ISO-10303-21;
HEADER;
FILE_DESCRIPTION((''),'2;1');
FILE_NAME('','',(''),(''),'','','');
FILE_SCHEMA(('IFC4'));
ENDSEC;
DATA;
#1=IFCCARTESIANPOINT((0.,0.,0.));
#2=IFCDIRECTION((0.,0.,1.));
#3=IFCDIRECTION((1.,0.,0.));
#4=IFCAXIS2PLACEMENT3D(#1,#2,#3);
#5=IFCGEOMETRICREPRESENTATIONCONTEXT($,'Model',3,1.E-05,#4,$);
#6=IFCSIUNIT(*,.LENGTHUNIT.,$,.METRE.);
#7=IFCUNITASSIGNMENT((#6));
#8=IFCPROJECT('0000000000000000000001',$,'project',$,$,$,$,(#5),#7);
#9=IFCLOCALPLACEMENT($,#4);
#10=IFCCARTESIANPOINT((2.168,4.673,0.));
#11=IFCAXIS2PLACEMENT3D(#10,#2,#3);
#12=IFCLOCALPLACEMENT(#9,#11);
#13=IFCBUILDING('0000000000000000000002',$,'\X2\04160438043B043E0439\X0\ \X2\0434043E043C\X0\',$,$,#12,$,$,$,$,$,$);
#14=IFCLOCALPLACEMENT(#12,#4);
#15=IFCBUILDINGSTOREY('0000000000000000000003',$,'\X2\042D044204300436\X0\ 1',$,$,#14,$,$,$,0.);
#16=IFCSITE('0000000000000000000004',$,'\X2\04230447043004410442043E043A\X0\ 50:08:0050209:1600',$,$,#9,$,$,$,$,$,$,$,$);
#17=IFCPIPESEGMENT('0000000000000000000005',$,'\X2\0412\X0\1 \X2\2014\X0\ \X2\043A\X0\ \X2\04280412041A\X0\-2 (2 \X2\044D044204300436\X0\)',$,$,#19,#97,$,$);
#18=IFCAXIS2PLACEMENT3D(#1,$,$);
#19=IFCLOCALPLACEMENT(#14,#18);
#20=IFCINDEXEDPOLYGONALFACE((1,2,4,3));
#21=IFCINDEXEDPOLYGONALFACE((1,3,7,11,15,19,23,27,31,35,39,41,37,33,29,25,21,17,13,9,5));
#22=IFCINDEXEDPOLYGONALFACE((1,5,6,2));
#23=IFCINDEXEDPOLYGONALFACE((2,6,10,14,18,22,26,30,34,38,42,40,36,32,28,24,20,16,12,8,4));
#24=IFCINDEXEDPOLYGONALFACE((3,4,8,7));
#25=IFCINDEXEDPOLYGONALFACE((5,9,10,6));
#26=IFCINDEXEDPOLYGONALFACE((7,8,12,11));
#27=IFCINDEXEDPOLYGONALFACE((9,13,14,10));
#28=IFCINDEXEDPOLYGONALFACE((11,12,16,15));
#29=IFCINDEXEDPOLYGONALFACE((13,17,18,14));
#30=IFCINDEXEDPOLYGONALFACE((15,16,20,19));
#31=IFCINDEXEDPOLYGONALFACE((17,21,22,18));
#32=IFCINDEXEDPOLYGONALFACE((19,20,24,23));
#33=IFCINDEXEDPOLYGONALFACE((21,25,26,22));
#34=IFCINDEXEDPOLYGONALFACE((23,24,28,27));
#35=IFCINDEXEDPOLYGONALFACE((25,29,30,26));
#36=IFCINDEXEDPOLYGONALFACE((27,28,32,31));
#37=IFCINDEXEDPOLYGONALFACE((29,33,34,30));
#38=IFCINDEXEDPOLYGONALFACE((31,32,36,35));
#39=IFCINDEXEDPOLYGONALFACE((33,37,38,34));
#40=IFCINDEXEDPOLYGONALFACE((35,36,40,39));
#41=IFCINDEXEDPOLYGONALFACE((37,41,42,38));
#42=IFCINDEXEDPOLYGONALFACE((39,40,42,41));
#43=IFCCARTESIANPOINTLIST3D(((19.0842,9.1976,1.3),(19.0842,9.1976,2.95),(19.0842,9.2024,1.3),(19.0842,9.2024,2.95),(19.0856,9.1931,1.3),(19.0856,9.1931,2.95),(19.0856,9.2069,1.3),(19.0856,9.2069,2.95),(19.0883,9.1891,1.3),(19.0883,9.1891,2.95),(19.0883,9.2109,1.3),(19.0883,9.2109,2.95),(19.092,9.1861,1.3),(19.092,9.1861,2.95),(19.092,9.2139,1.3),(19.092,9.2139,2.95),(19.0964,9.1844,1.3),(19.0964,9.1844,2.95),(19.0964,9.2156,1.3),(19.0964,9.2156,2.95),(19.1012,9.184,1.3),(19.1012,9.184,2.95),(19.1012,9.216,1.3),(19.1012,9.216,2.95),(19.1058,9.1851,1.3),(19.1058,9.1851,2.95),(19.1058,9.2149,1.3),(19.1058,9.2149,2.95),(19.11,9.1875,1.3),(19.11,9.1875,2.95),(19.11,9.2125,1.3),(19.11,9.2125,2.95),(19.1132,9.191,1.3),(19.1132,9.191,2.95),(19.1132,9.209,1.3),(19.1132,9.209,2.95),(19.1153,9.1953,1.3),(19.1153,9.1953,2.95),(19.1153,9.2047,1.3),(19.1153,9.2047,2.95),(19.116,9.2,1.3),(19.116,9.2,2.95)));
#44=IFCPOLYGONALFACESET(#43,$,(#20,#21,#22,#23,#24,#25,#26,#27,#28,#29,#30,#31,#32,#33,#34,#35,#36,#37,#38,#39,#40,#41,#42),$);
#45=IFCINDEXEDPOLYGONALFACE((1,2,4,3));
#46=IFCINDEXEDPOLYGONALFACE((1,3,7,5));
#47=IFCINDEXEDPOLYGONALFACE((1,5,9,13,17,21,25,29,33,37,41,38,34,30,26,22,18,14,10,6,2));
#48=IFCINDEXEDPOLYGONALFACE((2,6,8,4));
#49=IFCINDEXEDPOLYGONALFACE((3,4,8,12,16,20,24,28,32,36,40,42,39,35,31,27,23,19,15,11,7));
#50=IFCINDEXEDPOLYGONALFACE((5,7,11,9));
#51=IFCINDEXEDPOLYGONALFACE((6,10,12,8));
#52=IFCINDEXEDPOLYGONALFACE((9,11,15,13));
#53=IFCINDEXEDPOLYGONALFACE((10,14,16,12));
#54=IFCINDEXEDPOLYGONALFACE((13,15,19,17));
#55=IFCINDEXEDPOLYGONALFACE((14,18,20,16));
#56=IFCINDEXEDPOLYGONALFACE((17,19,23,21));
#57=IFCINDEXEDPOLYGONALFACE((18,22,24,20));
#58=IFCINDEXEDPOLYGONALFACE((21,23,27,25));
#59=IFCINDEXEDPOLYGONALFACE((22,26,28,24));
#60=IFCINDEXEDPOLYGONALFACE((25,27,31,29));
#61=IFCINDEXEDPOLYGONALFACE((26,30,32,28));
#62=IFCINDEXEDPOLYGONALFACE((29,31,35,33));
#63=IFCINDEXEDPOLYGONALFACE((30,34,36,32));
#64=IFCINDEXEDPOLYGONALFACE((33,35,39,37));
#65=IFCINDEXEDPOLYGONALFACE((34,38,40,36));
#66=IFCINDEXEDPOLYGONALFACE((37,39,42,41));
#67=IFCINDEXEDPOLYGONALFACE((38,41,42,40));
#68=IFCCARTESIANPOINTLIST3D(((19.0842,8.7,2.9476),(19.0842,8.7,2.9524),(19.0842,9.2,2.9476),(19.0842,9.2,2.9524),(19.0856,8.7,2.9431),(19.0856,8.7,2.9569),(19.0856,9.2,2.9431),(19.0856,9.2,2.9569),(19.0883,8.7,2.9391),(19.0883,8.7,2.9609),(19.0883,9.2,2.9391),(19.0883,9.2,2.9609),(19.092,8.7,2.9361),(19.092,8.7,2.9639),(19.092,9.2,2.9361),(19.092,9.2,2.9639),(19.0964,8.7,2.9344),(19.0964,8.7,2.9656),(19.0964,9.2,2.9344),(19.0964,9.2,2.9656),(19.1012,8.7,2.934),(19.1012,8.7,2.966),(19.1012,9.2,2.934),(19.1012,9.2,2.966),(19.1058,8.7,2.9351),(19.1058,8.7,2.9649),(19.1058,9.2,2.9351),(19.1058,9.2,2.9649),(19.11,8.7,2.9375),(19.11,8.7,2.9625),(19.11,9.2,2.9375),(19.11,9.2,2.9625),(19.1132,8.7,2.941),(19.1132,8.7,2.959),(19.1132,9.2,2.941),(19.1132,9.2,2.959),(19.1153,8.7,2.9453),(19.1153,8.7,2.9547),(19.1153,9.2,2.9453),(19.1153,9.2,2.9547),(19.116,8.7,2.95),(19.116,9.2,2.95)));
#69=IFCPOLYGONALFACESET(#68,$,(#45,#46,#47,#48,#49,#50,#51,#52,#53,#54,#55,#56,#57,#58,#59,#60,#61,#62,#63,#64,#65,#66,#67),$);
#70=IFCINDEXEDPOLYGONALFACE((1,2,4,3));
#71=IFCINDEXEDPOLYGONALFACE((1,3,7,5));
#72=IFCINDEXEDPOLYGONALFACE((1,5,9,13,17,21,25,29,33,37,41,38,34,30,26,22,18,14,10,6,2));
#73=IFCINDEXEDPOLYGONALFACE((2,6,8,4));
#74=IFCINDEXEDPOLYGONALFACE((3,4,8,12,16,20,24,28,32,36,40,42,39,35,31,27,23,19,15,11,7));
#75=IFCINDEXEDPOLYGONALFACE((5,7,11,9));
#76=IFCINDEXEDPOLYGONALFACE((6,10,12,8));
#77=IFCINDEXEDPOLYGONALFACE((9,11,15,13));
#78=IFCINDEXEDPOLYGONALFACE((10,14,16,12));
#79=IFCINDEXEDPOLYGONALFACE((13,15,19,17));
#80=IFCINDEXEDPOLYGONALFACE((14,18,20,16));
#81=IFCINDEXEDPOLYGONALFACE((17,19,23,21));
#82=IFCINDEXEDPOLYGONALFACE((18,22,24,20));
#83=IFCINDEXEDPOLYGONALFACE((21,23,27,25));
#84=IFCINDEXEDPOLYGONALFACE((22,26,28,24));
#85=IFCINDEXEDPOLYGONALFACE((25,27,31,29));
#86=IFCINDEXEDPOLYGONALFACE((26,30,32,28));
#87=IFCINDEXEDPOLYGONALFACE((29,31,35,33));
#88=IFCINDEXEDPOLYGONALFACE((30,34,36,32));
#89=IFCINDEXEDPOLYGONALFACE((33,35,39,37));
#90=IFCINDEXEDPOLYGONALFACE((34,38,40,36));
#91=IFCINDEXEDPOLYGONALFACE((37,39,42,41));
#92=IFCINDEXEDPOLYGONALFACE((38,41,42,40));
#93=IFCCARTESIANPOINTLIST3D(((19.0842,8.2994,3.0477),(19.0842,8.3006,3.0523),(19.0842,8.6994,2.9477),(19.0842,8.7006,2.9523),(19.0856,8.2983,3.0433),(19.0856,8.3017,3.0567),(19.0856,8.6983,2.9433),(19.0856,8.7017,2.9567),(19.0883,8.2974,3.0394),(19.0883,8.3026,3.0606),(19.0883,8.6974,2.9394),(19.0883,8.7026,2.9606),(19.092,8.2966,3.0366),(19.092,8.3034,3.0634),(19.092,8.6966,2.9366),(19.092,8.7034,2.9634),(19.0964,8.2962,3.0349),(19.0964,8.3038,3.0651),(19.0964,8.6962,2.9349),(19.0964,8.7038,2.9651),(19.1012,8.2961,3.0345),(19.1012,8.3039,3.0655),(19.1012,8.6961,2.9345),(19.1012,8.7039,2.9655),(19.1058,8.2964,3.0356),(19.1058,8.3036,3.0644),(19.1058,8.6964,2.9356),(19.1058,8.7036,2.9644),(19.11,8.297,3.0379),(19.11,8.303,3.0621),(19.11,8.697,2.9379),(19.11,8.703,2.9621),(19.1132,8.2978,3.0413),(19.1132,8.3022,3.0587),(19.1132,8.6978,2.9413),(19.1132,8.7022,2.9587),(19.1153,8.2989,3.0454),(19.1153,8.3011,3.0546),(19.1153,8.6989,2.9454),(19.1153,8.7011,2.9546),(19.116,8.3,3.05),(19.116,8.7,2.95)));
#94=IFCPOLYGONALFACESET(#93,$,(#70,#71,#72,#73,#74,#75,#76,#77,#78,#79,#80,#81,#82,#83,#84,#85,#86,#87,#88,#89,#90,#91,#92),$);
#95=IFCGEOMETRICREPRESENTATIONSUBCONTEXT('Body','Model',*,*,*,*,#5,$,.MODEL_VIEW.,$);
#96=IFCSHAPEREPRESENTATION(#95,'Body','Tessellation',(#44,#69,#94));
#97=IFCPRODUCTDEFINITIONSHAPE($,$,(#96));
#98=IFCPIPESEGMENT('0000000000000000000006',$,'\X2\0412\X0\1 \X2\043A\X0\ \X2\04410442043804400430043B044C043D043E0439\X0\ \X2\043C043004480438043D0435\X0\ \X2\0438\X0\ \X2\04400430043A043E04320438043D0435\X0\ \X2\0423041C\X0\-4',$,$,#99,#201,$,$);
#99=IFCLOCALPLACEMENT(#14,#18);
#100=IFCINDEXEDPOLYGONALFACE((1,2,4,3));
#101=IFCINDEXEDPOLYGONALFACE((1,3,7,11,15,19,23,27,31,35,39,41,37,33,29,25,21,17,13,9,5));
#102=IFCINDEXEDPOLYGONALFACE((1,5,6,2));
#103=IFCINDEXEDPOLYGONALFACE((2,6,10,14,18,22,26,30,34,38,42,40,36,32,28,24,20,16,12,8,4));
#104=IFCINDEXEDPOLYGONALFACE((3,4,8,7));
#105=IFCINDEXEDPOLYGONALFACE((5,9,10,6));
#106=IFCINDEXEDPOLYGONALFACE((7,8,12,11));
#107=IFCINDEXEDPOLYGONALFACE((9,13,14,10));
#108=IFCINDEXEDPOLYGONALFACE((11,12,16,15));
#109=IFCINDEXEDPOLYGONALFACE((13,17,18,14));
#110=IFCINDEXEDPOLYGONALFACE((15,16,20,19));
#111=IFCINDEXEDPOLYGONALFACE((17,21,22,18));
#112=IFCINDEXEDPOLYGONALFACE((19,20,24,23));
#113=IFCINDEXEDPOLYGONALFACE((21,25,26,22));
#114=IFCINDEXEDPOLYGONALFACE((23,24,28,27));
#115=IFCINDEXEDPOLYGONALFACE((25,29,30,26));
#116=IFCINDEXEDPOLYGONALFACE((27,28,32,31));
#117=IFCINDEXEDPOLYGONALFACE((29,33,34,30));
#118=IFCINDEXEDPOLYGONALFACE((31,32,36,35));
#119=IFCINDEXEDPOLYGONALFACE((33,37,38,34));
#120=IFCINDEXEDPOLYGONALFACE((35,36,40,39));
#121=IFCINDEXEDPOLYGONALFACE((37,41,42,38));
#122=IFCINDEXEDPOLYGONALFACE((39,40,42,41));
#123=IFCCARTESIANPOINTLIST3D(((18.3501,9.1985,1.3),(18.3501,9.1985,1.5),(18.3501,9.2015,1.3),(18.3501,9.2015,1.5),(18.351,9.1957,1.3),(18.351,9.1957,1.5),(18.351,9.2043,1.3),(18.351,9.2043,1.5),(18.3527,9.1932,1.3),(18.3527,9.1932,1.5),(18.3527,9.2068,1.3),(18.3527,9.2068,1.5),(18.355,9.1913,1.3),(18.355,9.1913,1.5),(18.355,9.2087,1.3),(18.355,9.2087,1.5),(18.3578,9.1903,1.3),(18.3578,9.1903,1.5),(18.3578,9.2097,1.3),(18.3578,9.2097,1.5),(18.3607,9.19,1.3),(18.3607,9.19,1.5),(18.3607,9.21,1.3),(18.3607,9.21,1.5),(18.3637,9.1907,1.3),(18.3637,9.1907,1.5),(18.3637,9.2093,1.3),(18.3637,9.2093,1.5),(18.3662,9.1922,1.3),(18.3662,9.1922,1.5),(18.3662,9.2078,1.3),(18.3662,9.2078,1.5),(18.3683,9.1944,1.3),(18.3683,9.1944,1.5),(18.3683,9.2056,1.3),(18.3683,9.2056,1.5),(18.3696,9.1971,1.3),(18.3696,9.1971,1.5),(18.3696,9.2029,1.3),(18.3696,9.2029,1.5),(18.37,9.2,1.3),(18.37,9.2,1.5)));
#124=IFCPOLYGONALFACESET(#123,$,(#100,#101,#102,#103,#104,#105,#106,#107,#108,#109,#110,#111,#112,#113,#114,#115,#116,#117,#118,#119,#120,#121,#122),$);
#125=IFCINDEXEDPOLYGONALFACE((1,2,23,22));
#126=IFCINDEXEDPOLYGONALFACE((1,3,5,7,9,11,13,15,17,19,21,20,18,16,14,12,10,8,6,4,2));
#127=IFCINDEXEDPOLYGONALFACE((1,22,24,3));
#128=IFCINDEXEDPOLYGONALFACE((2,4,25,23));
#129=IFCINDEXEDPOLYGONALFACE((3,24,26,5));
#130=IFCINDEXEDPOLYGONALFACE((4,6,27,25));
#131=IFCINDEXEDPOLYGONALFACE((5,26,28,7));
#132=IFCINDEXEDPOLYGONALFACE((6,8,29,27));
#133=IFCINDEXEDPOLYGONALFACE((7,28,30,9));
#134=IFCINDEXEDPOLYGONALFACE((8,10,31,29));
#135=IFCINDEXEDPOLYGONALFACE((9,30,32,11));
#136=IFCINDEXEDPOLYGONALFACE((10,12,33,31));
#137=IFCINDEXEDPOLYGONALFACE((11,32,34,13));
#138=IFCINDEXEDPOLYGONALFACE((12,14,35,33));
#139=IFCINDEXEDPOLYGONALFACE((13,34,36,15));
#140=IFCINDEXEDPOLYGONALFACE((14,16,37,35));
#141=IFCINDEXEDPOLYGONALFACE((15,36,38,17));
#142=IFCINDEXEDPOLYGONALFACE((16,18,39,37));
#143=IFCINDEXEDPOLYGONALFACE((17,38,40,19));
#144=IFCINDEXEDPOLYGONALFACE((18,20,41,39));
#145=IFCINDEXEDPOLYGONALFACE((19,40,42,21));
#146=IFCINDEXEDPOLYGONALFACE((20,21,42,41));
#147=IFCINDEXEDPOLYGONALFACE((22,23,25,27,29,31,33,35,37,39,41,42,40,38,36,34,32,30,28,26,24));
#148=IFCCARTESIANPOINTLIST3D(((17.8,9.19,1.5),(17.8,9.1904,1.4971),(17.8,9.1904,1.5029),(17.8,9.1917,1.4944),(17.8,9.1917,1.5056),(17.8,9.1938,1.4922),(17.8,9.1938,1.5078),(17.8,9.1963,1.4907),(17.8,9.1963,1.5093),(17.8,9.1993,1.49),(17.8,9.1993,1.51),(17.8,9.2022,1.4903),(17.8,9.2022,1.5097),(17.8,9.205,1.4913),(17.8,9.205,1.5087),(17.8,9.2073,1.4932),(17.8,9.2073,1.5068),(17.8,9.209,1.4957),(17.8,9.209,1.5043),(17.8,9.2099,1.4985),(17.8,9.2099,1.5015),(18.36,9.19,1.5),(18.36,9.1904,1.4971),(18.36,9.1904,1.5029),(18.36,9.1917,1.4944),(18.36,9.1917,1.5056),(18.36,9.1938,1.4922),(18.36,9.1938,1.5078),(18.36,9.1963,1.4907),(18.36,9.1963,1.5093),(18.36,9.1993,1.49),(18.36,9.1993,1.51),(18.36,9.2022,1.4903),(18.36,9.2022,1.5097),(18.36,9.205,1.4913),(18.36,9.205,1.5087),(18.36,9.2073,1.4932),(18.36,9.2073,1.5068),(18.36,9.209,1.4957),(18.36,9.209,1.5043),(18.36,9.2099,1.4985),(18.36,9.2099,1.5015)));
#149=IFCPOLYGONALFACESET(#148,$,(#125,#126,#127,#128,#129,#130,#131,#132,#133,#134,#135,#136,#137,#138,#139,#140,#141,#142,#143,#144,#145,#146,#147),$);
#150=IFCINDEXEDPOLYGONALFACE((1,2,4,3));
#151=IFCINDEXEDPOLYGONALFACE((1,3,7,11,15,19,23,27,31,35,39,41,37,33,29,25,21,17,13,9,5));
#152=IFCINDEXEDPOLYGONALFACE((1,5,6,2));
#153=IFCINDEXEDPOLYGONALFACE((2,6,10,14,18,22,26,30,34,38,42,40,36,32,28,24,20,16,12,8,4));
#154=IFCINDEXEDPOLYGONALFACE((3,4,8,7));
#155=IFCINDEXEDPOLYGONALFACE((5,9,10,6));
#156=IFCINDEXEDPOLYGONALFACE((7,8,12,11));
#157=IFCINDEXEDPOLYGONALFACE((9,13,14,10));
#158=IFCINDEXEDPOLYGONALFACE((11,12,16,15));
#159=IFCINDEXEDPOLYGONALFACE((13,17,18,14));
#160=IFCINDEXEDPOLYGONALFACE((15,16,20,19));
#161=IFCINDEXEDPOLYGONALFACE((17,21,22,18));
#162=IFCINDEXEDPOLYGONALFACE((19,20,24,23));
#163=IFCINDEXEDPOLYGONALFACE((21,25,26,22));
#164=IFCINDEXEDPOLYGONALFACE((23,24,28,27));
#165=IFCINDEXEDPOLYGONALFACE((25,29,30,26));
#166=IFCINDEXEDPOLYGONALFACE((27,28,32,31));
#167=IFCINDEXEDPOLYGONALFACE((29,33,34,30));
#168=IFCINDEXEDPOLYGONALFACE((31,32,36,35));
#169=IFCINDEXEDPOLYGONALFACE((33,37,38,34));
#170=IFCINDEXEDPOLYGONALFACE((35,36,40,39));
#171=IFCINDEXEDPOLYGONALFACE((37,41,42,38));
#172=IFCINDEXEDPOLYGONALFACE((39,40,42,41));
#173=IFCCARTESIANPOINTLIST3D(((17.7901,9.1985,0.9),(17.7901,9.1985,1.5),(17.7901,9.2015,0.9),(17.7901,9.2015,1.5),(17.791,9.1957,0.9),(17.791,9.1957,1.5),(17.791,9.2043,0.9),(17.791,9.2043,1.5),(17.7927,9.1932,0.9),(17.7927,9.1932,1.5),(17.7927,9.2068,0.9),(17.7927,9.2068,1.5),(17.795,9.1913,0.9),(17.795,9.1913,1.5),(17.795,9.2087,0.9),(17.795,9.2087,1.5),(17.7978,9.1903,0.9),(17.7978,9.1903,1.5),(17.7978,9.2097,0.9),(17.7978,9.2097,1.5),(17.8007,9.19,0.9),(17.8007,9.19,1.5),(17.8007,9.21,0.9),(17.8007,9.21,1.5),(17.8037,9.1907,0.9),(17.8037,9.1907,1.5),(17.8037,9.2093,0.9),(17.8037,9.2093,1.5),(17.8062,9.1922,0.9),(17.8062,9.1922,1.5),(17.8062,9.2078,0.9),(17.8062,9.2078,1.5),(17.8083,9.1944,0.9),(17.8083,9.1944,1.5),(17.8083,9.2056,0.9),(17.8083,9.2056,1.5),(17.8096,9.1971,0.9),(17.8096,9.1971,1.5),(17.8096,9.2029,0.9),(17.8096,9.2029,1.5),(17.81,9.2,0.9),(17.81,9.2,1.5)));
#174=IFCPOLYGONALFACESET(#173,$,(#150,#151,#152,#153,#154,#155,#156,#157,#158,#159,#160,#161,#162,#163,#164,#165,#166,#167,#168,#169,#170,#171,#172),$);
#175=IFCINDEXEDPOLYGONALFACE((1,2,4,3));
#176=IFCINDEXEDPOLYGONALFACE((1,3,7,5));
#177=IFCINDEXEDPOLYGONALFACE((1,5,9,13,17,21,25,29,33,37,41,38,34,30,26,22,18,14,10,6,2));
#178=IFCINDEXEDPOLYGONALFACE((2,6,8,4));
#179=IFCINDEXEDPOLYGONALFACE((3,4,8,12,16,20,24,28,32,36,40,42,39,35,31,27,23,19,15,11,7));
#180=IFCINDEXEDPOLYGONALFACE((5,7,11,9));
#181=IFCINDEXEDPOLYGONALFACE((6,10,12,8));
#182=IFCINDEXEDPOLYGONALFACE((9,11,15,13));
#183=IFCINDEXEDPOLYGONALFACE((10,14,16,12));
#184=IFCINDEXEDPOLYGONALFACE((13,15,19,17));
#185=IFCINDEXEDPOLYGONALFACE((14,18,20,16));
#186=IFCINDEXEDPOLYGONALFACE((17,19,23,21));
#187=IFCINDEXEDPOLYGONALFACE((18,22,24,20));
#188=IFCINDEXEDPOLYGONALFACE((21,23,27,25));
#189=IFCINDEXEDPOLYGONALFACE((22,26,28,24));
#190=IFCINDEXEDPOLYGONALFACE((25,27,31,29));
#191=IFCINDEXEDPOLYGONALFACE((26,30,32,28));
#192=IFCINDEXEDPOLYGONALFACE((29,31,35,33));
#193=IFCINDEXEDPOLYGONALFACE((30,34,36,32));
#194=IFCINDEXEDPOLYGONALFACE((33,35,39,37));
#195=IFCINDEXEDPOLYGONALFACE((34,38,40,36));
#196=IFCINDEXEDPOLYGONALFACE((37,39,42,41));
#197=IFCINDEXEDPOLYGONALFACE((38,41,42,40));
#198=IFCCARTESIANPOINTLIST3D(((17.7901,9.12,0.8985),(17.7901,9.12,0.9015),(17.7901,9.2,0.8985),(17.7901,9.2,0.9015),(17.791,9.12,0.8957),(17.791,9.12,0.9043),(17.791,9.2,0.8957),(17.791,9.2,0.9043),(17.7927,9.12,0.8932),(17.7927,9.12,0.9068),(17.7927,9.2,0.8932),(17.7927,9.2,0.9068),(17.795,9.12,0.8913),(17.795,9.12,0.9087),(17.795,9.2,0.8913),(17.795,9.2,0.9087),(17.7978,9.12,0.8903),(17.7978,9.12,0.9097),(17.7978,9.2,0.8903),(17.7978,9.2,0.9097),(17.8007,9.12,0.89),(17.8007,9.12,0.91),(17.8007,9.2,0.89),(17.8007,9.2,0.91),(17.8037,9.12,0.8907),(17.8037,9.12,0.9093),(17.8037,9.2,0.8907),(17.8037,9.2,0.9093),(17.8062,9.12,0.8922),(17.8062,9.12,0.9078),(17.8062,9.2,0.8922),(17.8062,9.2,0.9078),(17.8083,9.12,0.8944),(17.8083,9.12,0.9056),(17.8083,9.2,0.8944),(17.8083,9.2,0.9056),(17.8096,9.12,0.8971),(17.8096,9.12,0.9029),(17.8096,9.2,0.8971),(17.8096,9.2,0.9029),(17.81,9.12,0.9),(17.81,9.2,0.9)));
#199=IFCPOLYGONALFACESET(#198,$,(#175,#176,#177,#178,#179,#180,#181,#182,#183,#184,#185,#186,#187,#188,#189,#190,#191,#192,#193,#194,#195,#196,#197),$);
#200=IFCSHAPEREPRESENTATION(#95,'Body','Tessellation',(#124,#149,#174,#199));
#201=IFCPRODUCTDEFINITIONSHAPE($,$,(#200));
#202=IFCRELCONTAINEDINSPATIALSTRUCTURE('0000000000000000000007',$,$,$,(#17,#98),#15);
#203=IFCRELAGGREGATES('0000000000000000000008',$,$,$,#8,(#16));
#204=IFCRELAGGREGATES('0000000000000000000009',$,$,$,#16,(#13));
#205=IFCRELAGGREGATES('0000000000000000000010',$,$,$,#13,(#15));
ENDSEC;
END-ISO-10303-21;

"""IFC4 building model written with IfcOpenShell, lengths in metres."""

from ifc_helpers import new_model, si_unit, frame, origin_with_axes, origin_2d, place, context, subcontext, project, spatial, circle, extrude, element, save


model = new_model("IFC4")

# Units and contexts
model_context = context("Model", 3, precision=1e-05, world=origin_with_axes())
body_context = subcontext(model_context, "Body", "Model", "MODEL_VIEW")
ifc_project = project(units=[si_unit("LENGTHUNIT", "METRE")], contexts=[model_context])

# Site, building, storey
site_placement = place(None, origin_with_axes())
site = spatial("IfcSite", under=ifc_project, at=site_placement, Name="Участок 50:08:0050209:1600")
building_placement = place(site_placement, frame((2.168, 4.673, 0.0), z_axis=(0.0, 0.0, 1.0), x_axis=(1.0, 0.0, 0.0)))
building = spatial("IfcBuilding", under=site, at=building_placement, Name="Жилой дом")
storey_placement = place(building_placement, origin_with_axes())
storey = spatial("IfcBuildingStorey", under=building, at=storey_placement, Name="Этаж 1", Elevation=0.0)

# Pipe segments
pipe_segment_1_placement = place(storey_placement, origin_with_axes())
element("IfcPipeSegment", 1, at=pipe_segment_1_placement, inside=storey, Name="В1 — к ШВК-2 (2 этаж)", context=body_context, shape_type="SweptSolid", body=[
    extrude(circle(Radius=0.016, at=origin_2d()), frame((19.1, 9.2, 1.3), z_axis=(0.0, 0.0, 1.0), x_axis=(1.0, 0.0, 0.0)), (0.0, 0.0, 1.0), 1.65),
    extrude(circle(Radius=0.016, at=origin_2d()), frame((19.1, 9.2, 2.95), z_axis=(0.0, -1.0, 0.0), x_axis=(1.0, 0.0, 0.0)), (0.0, 0.0, 1.0), 0.5),
    extrude(circle(Radius=0.016, at=origin_2d()), frame((19.1, 8.7, 2.95), z_axis=(0.0, -0.970143, 0.242536), x_axis=(1.0, 0.0, 0.0)), (0.0, 0.0, 1.0), 0.4123),
])
pipe_segment_2_placement = place(storey_placement, origin_with_axes())
element("IfcPipeSegment", 2, at=pipe_segment_2_placement, inside=storey, Name="В1 к стиральной машине и раковине УМ-4", context=body_context, shape_type="SweptSolid", body=[
    extrude(circle(Radius=0.01, at=origin_2d()), frame((18.36, 9.2, 1.3), z_axis=(0.0, 0.0, 1.0), x_axis=(1.0, 0.0, 0.0)), (0.0, 0.0, 1.0), 0.2),
    extrude(circle(Radius=0.01, at=origin_2d()), frame((18.36, 9.2, 1.5), z_axis=(-1.0, 0.0, 0.0), x_axis=(0.0, -1.0, 0.0)), (0.0, 0.0, 1.0), 0.56),
    extrude(circle(Radius=0.01, at=origin_2d()), frame((17.8, 9.2, 1.5), z_axis=(0.0, 0.0, -1.0), x_axis=(1.0, 0.0, 0.0)), (0.0, 0.0, 1.0), 0.6),
    extrude(circle(Radius=0.01, at=origin_2d()), frame((17.8, 9.2, 0.9), z_axis=(0.0, -1.0, 0.0), x_axis=(1.0, 0.0, 0.0)), (0.0, 0.0, 1.0), 0.08),
])

save(model, "model.ifc")
